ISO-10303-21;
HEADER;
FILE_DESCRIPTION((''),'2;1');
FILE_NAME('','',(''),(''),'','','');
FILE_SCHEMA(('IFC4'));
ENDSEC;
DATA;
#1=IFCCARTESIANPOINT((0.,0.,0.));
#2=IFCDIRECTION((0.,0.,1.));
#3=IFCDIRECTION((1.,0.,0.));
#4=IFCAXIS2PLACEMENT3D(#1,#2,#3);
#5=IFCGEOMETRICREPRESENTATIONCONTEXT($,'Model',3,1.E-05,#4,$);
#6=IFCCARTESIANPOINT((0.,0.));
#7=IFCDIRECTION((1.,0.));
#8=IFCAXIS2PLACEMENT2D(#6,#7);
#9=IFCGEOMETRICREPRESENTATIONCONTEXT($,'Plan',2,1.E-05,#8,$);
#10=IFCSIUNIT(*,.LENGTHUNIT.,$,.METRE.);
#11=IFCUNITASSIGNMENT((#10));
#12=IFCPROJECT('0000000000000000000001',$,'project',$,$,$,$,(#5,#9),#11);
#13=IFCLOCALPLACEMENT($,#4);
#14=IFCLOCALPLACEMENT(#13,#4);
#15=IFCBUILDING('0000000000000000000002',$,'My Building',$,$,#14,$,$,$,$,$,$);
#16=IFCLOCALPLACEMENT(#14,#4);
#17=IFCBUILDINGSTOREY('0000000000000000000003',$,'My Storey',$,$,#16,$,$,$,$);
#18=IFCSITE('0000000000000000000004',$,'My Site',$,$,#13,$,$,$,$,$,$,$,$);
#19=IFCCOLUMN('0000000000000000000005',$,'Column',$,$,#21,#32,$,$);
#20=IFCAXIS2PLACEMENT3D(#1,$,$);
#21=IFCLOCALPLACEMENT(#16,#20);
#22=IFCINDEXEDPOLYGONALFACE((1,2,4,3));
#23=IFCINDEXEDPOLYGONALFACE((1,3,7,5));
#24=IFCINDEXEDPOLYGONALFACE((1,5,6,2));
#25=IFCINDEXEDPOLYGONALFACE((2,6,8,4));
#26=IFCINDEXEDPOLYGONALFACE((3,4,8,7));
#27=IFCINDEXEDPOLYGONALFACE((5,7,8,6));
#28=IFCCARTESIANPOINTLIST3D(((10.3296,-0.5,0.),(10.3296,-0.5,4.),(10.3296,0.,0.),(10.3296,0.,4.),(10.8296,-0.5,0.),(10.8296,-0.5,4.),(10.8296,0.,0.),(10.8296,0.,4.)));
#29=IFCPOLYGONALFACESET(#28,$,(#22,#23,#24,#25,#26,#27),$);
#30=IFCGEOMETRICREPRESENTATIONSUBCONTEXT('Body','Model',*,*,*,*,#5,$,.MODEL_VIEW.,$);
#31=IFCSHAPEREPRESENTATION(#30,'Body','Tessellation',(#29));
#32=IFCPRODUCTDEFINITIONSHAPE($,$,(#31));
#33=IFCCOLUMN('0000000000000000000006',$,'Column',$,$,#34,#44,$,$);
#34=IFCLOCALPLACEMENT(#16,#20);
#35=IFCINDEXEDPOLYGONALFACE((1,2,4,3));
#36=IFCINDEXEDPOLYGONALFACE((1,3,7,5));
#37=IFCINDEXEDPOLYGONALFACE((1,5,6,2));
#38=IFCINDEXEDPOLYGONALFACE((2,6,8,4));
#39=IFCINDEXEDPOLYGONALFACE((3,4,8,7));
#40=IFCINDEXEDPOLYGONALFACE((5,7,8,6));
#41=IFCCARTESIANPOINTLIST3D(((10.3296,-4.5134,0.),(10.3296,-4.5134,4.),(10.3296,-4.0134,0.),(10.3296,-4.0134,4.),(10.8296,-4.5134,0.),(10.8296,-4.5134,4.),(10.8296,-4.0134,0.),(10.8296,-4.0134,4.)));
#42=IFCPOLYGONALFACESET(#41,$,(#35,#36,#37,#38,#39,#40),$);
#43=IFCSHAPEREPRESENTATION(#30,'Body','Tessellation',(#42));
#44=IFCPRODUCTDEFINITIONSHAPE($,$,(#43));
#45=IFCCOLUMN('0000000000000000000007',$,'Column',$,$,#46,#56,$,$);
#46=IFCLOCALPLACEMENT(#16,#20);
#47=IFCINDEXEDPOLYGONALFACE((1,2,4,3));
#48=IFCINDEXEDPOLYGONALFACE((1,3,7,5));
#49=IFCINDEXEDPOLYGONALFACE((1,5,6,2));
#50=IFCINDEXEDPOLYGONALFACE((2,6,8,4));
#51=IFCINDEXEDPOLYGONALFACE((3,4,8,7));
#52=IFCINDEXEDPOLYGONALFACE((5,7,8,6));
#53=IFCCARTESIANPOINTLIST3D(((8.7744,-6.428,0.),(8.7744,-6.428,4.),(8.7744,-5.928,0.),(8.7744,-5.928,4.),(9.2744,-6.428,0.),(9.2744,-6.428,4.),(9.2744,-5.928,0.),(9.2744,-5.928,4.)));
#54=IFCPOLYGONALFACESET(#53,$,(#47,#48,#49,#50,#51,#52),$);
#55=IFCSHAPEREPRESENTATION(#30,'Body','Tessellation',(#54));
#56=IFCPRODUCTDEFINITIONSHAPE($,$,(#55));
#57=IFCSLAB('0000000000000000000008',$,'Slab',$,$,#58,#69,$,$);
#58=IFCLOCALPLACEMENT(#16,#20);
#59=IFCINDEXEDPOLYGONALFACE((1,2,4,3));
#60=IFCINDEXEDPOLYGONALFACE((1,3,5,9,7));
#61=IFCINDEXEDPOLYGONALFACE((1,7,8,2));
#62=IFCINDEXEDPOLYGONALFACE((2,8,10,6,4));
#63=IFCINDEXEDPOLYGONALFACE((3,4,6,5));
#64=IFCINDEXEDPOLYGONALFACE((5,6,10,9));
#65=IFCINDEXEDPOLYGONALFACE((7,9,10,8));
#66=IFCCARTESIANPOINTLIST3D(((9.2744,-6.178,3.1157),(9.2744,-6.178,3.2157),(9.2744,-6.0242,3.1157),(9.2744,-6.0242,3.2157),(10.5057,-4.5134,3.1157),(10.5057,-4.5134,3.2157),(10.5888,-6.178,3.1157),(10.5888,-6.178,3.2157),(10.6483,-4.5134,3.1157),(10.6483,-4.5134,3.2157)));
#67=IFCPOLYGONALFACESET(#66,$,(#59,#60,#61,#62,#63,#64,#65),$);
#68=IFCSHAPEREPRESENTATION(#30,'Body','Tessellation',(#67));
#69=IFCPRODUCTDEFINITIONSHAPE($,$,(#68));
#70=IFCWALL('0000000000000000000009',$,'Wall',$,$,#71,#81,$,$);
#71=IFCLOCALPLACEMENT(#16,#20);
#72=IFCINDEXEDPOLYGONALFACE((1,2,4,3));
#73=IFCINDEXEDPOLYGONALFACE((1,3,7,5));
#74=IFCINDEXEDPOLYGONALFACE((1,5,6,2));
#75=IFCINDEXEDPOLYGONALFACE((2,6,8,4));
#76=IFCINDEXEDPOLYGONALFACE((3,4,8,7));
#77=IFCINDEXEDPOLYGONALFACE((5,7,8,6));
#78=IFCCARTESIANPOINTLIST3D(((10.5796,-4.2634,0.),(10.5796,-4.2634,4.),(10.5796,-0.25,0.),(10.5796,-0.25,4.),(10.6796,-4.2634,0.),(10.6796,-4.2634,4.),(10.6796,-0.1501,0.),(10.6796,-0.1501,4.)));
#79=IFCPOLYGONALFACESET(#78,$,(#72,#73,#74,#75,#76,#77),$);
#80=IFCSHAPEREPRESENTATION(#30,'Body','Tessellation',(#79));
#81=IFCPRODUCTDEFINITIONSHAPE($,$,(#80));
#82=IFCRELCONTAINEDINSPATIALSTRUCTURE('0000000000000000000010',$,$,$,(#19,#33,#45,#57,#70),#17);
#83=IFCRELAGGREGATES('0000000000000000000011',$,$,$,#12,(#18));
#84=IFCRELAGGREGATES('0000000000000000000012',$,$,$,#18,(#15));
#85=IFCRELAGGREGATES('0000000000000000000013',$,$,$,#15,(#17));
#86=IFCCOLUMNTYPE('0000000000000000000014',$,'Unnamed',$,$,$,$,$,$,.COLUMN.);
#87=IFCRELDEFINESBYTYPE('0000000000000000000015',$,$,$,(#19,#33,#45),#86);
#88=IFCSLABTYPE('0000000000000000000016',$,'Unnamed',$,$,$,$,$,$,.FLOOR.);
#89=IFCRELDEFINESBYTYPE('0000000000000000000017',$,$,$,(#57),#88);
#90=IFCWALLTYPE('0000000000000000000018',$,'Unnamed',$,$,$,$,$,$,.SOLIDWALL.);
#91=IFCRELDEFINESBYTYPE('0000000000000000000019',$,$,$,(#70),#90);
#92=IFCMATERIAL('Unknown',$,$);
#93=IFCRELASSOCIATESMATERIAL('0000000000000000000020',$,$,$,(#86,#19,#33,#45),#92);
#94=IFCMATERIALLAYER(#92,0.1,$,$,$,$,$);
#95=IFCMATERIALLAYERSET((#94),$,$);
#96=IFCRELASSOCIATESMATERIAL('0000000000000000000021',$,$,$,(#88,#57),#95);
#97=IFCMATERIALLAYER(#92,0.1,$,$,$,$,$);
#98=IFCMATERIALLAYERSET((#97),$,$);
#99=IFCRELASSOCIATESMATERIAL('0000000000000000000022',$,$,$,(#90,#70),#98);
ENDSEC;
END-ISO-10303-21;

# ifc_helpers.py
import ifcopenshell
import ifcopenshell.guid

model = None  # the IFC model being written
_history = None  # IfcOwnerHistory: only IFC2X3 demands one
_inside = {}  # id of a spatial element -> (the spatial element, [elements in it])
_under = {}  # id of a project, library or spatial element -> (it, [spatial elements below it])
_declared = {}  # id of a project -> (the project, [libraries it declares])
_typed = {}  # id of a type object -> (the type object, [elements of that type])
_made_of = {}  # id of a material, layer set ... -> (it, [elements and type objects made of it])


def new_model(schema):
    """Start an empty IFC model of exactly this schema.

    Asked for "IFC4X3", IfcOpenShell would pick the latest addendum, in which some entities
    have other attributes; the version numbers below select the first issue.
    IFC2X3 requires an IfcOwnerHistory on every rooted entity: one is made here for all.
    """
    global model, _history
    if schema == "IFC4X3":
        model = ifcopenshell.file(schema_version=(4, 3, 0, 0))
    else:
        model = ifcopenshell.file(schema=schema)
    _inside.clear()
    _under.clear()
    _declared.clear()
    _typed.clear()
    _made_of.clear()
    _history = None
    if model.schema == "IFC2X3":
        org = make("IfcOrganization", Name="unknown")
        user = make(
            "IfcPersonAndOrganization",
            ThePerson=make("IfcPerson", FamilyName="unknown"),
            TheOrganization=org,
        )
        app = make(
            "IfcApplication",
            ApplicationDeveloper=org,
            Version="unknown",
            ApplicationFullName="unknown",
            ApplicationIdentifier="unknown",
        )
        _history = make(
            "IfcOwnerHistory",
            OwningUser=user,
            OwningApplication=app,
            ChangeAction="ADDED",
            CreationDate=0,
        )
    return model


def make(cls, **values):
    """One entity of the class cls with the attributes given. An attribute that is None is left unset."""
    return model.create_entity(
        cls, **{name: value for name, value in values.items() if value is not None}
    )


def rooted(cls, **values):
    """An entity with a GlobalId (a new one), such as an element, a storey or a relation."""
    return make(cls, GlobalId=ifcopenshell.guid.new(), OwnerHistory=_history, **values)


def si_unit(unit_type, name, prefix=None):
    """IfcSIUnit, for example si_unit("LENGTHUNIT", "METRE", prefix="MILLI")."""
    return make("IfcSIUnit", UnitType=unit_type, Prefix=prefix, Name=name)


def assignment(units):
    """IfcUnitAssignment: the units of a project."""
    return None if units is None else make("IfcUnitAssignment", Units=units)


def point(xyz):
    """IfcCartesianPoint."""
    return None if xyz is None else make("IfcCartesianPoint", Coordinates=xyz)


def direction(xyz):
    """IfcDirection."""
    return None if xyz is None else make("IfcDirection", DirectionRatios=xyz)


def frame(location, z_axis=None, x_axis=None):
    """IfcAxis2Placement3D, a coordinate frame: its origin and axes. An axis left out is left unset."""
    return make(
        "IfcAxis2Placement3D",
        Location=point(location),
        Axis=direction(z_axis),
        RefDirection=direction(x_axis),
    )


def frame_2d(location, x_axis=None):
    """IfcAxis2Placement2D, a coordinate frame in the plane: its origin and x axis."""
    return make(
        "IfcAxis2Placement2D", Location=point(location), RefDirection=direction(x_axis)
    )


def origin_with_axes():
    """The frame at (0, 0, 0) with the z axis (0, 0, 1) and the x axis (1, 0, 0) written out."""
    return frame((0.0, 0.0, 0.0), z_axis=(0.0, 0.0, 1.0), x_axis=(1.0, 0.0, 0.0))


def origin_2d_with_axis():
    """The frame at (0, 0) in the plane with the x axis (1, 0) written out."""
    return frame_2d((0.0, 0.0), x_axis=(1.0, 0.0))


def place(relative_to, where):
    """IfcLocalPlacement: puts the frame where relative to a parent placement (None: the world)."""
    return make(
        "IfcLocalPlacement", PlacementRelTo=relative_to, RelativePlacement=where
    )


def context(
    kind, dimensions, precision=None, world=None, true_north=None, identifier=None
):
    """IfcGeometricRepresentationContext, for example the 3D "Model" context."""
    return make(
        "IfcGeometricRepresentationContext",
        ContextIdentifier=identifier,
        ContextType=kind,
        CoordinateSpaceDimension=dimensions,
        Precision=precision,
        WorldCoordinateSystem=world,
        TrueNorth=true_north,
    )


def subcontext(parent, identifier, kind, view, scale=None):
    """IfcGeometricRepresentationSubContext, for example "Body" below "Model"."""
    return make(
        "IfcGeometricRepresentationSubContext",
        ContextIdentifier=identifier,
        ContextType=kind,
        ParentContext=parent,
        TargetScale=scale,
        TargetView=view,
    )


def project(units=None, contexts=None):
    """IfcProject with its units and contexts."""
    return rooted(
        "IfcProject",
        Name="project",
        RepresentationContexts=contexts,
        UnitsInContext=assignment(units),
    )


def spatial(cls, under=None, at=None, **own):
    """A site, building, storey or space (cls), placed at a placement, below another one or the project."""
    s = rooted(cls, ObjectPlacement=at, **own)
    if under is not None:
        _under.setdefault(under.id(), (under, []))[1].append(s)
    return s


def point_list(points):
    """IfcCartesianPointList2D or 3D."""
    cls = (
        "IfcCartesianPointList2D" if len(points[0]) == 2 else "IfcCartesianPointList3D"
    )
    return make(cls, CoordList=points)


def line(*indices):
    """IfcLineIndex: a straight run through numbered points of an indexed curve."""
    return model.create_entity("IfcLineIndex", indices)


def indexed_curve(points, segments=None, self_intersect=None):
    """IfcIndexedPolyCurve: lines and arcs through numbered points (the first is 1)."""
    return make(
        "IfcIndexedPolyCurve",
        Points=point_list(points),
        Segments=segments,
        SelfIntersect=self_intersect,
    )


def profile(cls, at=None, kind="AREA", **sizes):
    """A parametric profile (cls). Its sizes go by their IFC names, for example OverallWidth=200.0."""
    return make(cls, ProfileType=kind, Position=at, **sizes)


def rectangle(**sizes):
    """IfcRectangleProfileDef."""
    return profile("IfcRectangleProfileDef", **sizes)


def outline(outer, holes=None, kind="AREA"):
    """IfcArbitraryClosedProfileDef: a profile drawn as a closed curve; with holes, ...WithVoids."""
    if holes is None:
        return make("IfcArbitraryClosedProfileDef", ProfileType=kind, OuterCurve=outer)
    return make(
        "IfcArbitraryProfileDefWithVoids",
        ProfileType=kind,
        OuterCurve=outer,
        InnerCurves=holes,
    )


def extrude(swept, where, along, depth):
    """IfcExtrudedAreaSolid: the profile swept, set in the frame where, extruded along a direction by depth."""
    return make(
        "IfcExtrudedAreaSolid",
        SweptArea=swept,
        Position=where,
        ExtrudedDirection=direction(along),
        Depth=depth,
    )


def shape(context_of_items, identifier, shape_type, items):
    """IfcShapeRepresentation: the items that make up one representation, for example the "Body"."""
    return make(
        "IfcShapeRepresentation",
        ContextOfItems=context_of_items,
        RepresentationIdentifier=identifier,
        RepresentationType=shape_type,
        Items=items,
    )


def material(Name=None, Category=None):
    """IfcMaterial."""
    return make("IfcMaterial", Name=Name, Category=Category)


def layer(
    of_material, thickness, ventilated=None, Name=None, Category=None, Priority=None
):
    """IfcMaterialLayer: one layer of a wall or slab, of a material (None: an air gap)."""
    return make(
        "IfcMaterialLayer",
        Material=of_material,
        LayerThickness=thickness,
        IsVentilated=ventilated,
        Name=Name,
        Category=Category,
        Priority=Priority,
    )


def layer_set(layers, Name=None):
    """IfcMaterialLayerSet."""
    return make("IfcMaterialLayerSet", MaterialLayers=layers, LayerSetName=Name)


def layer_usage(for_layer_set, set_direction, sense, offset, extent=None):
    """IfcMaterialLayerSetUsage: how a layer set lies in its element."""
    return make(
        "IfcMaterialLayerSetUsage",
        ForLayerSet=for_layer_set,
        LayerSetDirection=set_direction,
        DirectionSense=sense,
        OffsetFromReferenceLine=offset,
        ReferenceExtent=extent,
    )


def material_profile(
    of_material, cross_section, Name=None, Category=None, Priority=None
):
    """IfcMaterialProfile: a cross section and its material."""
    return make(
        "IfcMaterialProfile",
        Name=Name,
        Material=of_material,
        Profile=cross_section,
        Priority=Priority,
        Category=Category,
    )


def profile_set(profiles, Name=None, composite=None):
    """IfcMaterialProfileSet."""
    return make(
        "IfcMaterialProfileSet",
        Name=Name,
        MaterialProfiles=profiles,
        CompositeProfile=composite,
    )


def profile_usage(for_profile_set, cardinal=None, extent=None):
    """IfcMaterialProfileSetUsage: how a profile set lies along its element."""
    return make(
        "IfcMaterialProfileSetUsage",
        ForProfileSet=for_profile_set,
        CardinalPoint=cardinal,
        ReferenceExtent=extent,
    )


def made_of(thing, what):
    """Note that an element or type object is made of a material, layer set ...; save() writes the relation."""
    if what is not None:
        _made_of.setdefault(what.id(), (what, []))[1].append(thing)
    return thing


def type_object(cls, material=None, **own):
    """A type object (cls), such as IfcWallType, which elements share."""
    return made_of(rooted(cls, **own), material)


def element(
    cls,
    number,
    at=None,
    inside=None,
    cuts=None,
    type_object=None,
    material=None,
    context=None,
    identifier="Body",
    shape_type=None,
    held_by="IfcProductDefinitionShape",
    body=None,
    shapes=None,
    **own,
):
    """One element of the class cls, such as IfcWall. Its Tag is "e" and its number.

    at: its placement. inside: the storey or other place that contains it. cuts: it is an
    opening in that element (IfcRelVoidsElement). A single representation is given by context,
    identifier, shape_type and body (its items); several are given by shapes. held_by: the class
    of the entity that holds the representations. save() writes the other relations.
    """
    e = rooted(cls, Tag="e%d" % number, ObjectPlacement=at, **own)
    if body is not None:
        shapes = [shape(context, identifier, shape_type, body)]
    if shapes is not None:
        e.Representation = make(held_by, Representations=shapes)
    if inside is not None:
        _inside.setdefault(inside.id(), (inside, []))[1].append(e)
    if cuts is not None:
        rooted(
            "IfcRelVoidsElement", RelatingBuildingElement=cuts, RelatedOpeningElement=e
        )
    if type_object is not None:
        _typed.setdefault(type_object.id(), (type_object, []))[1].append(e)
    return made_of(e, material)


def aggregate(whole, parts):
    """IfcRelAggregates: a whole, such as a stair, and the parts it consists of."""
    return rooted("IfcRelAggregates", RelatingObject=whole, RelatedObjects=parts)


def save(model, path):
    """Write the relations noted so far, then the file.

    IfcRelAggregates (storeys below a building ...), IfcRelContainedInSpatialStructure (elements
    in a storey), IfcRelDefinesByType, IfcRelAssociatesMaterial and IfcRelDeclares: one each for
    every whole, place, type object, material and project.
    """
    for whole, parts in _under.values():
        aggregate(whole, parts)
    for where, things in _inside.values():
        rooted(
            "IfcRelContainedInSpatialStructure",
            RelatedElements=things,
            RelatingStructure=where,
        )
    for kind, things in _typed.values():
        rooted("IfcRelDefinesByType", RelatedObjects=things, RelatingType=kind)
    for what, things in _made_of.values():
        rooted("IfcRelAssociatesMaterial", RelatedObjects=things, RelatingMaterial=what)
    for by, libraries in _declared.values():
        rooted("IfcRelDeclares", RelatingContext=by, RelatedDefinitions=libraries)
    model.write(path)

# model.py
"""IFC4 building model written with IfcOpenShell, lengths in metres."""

from ifc_helpers import new_model, si_unit, frame, origin_with_axes, origin_2d_with_axis, place, context, subcontext, project, spatial, line, indexed_curve, rectangle, outline, extrude, material, layer, layer_set, layer_usage, material_profile, profile_set, profile_usage, type_object, element, save


model = new_model("IFC4")

# Units and contexts
model_context = context("Model", 3, precision=1e-05, world=origin_with_axes())
plan_context = context("Plan", 2, precision=1e-05, world=origin_2d_with_axis())
body_context_1 = subcontext(model_context, "Body", "Model", "MODEL_VIEW")
ifc_project = project(units=[si_unit("LENGTHUNIT", "METRE")], contexts=[model_context, plan_context])

# Site, building, storey
site_placement = place(None, origin_with_axes())
site = spatial("IfcSite", under=ifc_project, at=site_placement, Name="My Site")
building_placement = place(site_placement, origin_with_axes())
building = spatial("IfcBuilding", under=site, at=building_placement, Name="My Building")
storey_placement = place(building_placement, origin_with_axes())
storey = spatial("IfcBuildingStorey", under=building, at=storey_placement, Name="My Storey")

# Columns
ifc_material = material(Name="Unknown")
ifc_material_profile_1 = material_profile(ifc_material, rectangle(XDim=0.5, YDim=0.5))
ifc_profile_set_1 = profile_set([ifc_material_profile_1])
ifc_profile_usage_1 = profile_usage(ifc_profile_set_1, cardinal=5)
column_type = type_object("IfcColumnType", Name="Unnamed", PredefinedType="COLUMN", material=ifc_profile_set_1)
column_1_placement = place(storey_placement, frame((10.5796, -0.25, 0.0), z_axis=(0.0, 0.0, 1.0), x_axis=(1.0, 0.0, 0.0)))
element("IfcColumn", 1, at=column_1_placement, inside=storey, type_object=column_type, material=ifc_profile_usage_1, Name="Column", context=body_context_1, shape_type="SweptSolid", body=[
    extrude(rectangle(XDim=0.5, YDim=0.5), origin_with_axes(), (0.0, 0.0, 1.0), 4.0),
])
ifc_profile_usage_2 = profile_usage(ifc_profile_set_1, cardinal=5)
column_2_placement = place(storey_placement, frame((10.5796, -4.2634, 0.0), z_axis=(0.0, 0.0, 1.0), x_axis=(1.0, 0.0, 0.0)))
element("IfcColumn", 2, at=column_2_placement, inside=storey, type_object=column_type, material=ifc_profile_usage_2, Name="Column", context=body_context_1, shape_type="SweptSolid", body=[
    extrude(rectangle(XDim=0.5, YDim=0.5), origin_with_axes(), (0.0, 0.0, 1.0), 4.0),
])
ifc_profile_usage_3 = profile_usage(ifc_profile_set_1, cardinal=5)
column_3_placement = place(storey_placement, frame((9.0244, -6.178, 0.0), z_axis=(0.0, 0.0, 1.0), x_axis=(1.0, 0.0, 0.0)))
element("IfcColumn", 3, at=column_3_placement, inside=storey, type_object=column_type, material=ifc_profile_usage_3, Name="Column", context=body_context_1, shape_type="SweptSolid", body=[
    extrude(rectangle(XDim=0.5, YDim=0.5), origin_with_axes(), (0.0, 0.0, 1.0), 4.0),
])

# Slab
ifc_layer_1 = layer(ifc_material, 0.1)
ifc_layer_set_1 = layer_set([ifc_layer_1])
ifc_layer_usage_1 = layer_usage(ifc_layer_set_1, "AXIS3", "POSITIVE", -0.1)
slab_type = type_object("IfcSlabType", Name="Unnamed", PredefinedType="FLOOR", material=ifc_layer_set_1)
slab_placement = place(storey_placement, frame((10.5888, -6.178, 3.2157), z_axis=(0.0, 0.0, 1.0), x_axis=(1.0, 0.0, 0.0)))
element("IfcSlab", 4, at=slab_placement, inside=storey, type_object=slab_type, material=ifc_layer_usage_1, Name="Slab", context=body_context_1, shape_type="SweptSolid", body=[
    extrude(outline(indexed_curve([(0.0, 0.0), (-1.3143, 0.0), (-1.3143, 0.1538), (-0.083, 1.6646), (0.0595, 1.6646), (0.0, 0.0)])), frame((0.0, 0.0, -0.1), z_axis=(0.0, 0.0, 1.0), x_axis=(1.0, 0.0, 0.0)), (0.0, 0.0, 1.0), 0.1),
])

# Wall
ifc_layer_2 = layer(ifc_material, 0.1)
ifc_layer_set_2 = layer_set([ifc_layer_2])
ifc_layer_usage_2 = layer_usage(ifc_layer_set_2, "AXIS2", "POSITIVE", 0.0)
wall_type = type_object("IfcWallType", Name="Unnamed", PredefinedType="SOLIDWALL", material=ifc_layer_set_2)
wall_1_placement = place(storey_placement, frame((10.5796, -0.25, 0.0), z_axis=(0.0, 0.0, 1.0), x_axis=(0.0, -1.0, 0.0)))
element("IfcWall", 5, at=wall_1_placement, inside=storey, type_object=wall_type, material=ifc_layer_usage_2, Name="Wall", context=body_context_1, shape_type="SweptSolid", body=[
    extrude(outline(indexed_curve([(0.0, 0.0), (-0.0999, 0.1), (4.0134, 0.1), (4.0134, 0.0)], segments=[line(1, 2, 3, 4, 1)])), origin_with_axes(), (0.0, 0.0, 1.0), 4.0),
])

save(model, "model.ifc")
